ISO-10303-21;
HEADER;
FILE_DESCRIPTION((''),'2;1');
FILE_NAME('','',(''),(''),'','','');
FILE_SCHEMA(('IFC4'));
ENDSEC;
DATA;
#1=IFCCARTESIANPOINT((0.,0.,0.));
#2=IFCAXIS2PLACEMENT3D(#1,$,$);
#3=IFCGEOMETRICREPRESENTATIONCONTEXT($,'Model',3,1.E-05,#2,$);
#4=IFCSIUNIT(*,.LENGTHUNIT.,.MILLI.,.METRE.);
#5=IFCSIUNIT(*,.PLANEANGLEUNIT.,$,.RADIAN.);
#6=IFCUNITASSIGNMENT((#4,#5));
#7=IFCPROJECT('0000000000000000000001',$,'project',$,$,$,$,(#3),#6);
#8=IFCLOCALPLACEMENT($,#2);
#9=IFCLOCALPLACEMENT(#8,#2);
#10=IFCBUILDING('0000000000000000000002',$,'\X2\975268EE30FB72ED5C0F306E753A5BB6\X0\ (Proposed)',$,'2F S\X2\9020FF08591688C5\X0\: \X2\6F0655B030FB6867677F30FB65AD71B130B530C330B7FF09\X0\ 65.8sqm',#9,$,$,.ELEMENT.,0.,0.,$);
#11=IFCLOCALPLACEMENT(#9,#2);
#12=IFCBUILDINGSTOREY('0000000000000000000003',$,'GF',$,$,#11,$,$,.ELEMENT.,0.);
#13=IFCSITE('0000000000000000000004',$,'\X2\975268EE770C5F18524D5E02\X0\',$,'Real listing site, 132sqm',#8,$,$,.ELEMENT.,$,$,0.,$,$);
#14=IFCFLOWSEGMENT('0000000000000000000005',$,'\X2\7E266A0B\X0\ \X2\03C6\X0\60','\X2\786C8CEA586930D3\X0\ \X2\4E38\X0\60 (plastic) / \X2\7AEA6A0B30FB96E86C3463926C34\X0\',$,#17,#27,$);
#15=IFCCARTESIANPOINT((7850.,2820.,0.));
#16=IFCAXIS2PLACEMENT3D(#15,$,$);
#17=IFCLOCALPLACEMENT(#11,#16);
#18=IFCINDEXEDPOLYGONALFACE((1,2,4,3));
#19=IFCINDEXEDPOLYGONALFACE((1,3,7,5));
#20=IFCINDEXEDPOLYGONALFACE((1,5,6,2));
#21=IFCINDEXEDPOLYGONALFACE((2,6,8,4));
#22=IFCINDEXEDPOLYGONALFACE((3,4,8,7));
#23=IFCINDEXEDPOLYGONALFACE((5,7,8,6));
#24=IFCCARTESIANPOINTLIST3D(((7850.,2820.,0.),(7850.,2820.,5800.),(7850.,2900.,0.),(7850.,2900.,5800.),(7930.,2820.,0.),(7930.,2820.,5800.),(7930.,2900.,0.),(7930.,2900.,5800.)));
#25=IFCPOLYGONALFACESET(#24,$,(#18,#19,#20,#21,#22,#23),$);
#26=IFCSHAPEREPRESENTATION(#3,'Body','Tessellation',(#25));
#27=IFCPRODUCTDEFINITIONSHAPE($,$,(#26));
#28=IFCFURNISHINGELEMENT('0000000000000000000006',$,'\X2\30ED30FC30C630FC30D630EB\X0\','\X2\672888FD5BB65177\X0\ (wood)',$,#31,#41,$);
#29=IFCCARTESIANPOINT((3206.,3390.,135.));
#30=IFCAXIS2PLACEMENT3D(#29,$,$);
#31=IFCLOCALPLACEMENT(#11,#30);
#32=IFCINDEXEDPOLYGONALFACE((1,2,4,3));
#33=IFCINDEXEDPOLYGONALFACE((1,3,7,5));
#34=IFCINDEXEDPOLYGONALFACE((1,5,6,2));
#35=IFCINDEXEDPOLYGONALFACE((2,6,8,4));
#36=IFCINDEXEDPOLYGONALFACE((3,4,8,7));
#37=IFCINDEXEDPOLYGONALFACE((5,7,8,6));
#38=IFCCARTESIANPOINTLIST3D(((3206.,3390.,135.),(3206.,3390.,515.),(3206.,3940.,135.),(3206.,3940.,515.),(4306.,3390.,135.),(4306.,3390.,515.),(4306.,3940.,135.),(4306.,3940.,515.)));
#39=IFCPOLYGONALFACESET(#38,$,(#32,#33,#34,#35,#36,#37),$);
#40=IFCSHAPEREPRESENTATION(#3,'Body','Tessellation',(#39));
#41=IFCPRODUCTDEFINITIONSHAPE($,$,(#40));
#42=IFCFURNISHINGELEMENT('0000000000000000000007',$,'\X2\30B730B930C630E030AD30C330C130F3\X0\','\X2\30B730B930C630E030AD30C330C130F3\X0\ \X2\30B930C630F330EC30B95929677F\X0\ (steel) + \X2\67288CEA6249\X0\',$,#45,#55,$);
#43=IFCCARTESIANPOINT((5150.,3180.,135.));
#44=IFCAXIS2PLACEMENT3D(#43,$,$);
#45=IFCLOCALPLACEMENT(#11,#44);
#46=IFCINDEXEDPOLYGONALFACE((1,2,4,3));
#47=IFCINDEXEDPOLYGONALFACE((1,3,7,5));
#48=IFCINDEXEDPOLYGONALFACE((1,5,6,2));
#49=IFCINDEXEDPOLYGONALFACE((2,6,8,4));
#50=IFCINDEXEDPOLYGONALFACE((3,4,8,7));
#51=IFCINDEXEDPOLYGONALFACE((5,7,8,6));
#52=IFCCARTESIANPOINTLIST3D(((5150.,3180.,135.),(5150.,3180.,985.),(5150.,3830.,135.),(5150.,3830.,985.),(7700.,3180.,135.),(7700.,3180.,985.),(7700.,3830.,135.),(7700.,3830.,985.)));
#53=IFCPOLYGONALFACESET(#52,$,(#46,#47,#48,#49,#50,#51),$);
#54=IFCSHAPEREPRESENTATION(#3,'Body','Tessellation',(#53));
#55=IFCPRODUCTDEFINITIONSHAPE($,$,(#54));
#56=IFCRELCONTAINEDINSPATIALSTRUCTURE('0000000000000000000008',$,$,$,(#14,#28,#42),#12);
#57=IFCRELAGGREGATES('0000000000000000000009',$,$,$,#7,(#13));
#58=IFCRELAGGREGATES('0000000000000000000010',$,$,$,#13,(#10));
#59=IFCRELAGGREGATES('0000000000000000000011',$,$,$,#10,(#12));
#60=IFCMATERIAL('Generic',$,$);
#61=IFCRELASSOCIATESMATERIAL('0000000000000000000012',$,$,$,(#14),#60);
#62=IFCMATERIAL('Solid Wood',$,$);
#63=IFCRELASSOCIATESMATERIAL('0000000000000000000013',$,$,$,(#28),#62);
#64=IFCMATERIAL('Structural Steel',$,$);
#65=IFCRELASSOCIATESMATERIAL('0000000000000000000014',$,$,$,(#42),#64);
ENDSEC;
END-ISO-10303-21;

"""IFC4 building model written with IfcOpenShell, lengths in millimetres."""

from ifc_helpers import new_model, si_unit, frame, frame_2d, origin, place, context, project, spatial, rectangle, extrude, material, element, save


model = new_model("IFC4")

# Units and contexts
model_context = context("Model", 3, precision=1e-05, world=origin())
ifc_project = project(units=[si_unit("LENGTHUNIT", "METRE", prefix="MILLI"), si_unit("PLANEANGLEUNIT", "RADIAN")], contexts=[model_context])

# Site, building, storey
site_placement = place(None, origin())
site = spatial("IfcSite", under=ifc_project, at=site_placement, Name="青森県弘前市", ObjectType="Real listing site, 132sqm", CompositionType="ELEMENT", RefElevation=0.0)
building_placement = place(site_placement, origin())
building = spatial("IfcBuilding", under=site, at=building_placement, Name="青森・狭小の町家 (Proposed)", ObjectType="2F S造（外装: 漆喰・桧板・断熱サッシ） 65.8sqm", CompositionType="ELEMENT", ElevationOfRefHeight=0.0, ElevationOfTerrain=0.0)
storey_placement = place(building_placement, origin())
storey = spatial("IfcBuildingStorey", under=building, at=storey_placement, Name="GF", CompositionType="ELEMENT", Elevation=0.0)

# Shared definitions
ifc_material_1 = material(Name="Solid Wood")

# Shared definitions
ifc_material_2 = material(Name="Generic")

# Flow segment
flow_segment_1_placement = place(storey_placement, frame((7850.0, 2820.0, 0.0)))
element("IfcFlowSegment", 1, at=flow_segment_1_placement, inside=storey, material=ifc_material_2, Name="縦樋 φ60", Description="硬質塩ビ 丸60 (plastic) / 竪樋・雨水排水", context=model_context, shape_type="SweptSolid", body=[
    extrude(rectangle(XDim=80.0, YDim=80.0, at=frame_2d((40.0, 40.0))), frame((7850.0, 2820.0, 0.0)), (0.0, 0.0, 1.0), 5800.0),
])

# Furnishing elements
furnishing_1_placement = place(storey_placement, frame((3206.0, 3390.0, 135.0)))
element("IfcFurnishingElement", 2, at=furnishing_1_placement, inside=storey, material=ifc_material_1, Name="ローテーブル", Description="木製家具 (wood)", context=model_context, shape_type="SweptSolid", body=[
    extrude(rectangle(XDim=1100.0, YDim=550.0, at=frame_2d((550.0, 275.0))), frame((3206.0, 3390.0, 135.0)), (0.0, 0.0, 1.0), 380.0),
])
ifc_material_3 = material(Name="Structural Steel")
furnishing_2_placement = place(storey_placement, frame((5150.0, 3180.0, 135.0)))
element("IfcFurnishingElement", 3, at=furnishing_2_placement, inside=storey, material=ifc_material_3, Name="システムキッチン", Description="システムキッチン ステンレス天板 (steel) + 木質扉", context=model_context, shape_type="SweptSolid", body=[
    extrude(rectangle(XDim=2550.0, YDim=650.0, at=frame_2d((1275.0, 325.0))), frame((5150.0, 3180.0, 135.0)), (0.0, 0.0, 1.0), 850.0),
])

save(model, "model.ifc")
